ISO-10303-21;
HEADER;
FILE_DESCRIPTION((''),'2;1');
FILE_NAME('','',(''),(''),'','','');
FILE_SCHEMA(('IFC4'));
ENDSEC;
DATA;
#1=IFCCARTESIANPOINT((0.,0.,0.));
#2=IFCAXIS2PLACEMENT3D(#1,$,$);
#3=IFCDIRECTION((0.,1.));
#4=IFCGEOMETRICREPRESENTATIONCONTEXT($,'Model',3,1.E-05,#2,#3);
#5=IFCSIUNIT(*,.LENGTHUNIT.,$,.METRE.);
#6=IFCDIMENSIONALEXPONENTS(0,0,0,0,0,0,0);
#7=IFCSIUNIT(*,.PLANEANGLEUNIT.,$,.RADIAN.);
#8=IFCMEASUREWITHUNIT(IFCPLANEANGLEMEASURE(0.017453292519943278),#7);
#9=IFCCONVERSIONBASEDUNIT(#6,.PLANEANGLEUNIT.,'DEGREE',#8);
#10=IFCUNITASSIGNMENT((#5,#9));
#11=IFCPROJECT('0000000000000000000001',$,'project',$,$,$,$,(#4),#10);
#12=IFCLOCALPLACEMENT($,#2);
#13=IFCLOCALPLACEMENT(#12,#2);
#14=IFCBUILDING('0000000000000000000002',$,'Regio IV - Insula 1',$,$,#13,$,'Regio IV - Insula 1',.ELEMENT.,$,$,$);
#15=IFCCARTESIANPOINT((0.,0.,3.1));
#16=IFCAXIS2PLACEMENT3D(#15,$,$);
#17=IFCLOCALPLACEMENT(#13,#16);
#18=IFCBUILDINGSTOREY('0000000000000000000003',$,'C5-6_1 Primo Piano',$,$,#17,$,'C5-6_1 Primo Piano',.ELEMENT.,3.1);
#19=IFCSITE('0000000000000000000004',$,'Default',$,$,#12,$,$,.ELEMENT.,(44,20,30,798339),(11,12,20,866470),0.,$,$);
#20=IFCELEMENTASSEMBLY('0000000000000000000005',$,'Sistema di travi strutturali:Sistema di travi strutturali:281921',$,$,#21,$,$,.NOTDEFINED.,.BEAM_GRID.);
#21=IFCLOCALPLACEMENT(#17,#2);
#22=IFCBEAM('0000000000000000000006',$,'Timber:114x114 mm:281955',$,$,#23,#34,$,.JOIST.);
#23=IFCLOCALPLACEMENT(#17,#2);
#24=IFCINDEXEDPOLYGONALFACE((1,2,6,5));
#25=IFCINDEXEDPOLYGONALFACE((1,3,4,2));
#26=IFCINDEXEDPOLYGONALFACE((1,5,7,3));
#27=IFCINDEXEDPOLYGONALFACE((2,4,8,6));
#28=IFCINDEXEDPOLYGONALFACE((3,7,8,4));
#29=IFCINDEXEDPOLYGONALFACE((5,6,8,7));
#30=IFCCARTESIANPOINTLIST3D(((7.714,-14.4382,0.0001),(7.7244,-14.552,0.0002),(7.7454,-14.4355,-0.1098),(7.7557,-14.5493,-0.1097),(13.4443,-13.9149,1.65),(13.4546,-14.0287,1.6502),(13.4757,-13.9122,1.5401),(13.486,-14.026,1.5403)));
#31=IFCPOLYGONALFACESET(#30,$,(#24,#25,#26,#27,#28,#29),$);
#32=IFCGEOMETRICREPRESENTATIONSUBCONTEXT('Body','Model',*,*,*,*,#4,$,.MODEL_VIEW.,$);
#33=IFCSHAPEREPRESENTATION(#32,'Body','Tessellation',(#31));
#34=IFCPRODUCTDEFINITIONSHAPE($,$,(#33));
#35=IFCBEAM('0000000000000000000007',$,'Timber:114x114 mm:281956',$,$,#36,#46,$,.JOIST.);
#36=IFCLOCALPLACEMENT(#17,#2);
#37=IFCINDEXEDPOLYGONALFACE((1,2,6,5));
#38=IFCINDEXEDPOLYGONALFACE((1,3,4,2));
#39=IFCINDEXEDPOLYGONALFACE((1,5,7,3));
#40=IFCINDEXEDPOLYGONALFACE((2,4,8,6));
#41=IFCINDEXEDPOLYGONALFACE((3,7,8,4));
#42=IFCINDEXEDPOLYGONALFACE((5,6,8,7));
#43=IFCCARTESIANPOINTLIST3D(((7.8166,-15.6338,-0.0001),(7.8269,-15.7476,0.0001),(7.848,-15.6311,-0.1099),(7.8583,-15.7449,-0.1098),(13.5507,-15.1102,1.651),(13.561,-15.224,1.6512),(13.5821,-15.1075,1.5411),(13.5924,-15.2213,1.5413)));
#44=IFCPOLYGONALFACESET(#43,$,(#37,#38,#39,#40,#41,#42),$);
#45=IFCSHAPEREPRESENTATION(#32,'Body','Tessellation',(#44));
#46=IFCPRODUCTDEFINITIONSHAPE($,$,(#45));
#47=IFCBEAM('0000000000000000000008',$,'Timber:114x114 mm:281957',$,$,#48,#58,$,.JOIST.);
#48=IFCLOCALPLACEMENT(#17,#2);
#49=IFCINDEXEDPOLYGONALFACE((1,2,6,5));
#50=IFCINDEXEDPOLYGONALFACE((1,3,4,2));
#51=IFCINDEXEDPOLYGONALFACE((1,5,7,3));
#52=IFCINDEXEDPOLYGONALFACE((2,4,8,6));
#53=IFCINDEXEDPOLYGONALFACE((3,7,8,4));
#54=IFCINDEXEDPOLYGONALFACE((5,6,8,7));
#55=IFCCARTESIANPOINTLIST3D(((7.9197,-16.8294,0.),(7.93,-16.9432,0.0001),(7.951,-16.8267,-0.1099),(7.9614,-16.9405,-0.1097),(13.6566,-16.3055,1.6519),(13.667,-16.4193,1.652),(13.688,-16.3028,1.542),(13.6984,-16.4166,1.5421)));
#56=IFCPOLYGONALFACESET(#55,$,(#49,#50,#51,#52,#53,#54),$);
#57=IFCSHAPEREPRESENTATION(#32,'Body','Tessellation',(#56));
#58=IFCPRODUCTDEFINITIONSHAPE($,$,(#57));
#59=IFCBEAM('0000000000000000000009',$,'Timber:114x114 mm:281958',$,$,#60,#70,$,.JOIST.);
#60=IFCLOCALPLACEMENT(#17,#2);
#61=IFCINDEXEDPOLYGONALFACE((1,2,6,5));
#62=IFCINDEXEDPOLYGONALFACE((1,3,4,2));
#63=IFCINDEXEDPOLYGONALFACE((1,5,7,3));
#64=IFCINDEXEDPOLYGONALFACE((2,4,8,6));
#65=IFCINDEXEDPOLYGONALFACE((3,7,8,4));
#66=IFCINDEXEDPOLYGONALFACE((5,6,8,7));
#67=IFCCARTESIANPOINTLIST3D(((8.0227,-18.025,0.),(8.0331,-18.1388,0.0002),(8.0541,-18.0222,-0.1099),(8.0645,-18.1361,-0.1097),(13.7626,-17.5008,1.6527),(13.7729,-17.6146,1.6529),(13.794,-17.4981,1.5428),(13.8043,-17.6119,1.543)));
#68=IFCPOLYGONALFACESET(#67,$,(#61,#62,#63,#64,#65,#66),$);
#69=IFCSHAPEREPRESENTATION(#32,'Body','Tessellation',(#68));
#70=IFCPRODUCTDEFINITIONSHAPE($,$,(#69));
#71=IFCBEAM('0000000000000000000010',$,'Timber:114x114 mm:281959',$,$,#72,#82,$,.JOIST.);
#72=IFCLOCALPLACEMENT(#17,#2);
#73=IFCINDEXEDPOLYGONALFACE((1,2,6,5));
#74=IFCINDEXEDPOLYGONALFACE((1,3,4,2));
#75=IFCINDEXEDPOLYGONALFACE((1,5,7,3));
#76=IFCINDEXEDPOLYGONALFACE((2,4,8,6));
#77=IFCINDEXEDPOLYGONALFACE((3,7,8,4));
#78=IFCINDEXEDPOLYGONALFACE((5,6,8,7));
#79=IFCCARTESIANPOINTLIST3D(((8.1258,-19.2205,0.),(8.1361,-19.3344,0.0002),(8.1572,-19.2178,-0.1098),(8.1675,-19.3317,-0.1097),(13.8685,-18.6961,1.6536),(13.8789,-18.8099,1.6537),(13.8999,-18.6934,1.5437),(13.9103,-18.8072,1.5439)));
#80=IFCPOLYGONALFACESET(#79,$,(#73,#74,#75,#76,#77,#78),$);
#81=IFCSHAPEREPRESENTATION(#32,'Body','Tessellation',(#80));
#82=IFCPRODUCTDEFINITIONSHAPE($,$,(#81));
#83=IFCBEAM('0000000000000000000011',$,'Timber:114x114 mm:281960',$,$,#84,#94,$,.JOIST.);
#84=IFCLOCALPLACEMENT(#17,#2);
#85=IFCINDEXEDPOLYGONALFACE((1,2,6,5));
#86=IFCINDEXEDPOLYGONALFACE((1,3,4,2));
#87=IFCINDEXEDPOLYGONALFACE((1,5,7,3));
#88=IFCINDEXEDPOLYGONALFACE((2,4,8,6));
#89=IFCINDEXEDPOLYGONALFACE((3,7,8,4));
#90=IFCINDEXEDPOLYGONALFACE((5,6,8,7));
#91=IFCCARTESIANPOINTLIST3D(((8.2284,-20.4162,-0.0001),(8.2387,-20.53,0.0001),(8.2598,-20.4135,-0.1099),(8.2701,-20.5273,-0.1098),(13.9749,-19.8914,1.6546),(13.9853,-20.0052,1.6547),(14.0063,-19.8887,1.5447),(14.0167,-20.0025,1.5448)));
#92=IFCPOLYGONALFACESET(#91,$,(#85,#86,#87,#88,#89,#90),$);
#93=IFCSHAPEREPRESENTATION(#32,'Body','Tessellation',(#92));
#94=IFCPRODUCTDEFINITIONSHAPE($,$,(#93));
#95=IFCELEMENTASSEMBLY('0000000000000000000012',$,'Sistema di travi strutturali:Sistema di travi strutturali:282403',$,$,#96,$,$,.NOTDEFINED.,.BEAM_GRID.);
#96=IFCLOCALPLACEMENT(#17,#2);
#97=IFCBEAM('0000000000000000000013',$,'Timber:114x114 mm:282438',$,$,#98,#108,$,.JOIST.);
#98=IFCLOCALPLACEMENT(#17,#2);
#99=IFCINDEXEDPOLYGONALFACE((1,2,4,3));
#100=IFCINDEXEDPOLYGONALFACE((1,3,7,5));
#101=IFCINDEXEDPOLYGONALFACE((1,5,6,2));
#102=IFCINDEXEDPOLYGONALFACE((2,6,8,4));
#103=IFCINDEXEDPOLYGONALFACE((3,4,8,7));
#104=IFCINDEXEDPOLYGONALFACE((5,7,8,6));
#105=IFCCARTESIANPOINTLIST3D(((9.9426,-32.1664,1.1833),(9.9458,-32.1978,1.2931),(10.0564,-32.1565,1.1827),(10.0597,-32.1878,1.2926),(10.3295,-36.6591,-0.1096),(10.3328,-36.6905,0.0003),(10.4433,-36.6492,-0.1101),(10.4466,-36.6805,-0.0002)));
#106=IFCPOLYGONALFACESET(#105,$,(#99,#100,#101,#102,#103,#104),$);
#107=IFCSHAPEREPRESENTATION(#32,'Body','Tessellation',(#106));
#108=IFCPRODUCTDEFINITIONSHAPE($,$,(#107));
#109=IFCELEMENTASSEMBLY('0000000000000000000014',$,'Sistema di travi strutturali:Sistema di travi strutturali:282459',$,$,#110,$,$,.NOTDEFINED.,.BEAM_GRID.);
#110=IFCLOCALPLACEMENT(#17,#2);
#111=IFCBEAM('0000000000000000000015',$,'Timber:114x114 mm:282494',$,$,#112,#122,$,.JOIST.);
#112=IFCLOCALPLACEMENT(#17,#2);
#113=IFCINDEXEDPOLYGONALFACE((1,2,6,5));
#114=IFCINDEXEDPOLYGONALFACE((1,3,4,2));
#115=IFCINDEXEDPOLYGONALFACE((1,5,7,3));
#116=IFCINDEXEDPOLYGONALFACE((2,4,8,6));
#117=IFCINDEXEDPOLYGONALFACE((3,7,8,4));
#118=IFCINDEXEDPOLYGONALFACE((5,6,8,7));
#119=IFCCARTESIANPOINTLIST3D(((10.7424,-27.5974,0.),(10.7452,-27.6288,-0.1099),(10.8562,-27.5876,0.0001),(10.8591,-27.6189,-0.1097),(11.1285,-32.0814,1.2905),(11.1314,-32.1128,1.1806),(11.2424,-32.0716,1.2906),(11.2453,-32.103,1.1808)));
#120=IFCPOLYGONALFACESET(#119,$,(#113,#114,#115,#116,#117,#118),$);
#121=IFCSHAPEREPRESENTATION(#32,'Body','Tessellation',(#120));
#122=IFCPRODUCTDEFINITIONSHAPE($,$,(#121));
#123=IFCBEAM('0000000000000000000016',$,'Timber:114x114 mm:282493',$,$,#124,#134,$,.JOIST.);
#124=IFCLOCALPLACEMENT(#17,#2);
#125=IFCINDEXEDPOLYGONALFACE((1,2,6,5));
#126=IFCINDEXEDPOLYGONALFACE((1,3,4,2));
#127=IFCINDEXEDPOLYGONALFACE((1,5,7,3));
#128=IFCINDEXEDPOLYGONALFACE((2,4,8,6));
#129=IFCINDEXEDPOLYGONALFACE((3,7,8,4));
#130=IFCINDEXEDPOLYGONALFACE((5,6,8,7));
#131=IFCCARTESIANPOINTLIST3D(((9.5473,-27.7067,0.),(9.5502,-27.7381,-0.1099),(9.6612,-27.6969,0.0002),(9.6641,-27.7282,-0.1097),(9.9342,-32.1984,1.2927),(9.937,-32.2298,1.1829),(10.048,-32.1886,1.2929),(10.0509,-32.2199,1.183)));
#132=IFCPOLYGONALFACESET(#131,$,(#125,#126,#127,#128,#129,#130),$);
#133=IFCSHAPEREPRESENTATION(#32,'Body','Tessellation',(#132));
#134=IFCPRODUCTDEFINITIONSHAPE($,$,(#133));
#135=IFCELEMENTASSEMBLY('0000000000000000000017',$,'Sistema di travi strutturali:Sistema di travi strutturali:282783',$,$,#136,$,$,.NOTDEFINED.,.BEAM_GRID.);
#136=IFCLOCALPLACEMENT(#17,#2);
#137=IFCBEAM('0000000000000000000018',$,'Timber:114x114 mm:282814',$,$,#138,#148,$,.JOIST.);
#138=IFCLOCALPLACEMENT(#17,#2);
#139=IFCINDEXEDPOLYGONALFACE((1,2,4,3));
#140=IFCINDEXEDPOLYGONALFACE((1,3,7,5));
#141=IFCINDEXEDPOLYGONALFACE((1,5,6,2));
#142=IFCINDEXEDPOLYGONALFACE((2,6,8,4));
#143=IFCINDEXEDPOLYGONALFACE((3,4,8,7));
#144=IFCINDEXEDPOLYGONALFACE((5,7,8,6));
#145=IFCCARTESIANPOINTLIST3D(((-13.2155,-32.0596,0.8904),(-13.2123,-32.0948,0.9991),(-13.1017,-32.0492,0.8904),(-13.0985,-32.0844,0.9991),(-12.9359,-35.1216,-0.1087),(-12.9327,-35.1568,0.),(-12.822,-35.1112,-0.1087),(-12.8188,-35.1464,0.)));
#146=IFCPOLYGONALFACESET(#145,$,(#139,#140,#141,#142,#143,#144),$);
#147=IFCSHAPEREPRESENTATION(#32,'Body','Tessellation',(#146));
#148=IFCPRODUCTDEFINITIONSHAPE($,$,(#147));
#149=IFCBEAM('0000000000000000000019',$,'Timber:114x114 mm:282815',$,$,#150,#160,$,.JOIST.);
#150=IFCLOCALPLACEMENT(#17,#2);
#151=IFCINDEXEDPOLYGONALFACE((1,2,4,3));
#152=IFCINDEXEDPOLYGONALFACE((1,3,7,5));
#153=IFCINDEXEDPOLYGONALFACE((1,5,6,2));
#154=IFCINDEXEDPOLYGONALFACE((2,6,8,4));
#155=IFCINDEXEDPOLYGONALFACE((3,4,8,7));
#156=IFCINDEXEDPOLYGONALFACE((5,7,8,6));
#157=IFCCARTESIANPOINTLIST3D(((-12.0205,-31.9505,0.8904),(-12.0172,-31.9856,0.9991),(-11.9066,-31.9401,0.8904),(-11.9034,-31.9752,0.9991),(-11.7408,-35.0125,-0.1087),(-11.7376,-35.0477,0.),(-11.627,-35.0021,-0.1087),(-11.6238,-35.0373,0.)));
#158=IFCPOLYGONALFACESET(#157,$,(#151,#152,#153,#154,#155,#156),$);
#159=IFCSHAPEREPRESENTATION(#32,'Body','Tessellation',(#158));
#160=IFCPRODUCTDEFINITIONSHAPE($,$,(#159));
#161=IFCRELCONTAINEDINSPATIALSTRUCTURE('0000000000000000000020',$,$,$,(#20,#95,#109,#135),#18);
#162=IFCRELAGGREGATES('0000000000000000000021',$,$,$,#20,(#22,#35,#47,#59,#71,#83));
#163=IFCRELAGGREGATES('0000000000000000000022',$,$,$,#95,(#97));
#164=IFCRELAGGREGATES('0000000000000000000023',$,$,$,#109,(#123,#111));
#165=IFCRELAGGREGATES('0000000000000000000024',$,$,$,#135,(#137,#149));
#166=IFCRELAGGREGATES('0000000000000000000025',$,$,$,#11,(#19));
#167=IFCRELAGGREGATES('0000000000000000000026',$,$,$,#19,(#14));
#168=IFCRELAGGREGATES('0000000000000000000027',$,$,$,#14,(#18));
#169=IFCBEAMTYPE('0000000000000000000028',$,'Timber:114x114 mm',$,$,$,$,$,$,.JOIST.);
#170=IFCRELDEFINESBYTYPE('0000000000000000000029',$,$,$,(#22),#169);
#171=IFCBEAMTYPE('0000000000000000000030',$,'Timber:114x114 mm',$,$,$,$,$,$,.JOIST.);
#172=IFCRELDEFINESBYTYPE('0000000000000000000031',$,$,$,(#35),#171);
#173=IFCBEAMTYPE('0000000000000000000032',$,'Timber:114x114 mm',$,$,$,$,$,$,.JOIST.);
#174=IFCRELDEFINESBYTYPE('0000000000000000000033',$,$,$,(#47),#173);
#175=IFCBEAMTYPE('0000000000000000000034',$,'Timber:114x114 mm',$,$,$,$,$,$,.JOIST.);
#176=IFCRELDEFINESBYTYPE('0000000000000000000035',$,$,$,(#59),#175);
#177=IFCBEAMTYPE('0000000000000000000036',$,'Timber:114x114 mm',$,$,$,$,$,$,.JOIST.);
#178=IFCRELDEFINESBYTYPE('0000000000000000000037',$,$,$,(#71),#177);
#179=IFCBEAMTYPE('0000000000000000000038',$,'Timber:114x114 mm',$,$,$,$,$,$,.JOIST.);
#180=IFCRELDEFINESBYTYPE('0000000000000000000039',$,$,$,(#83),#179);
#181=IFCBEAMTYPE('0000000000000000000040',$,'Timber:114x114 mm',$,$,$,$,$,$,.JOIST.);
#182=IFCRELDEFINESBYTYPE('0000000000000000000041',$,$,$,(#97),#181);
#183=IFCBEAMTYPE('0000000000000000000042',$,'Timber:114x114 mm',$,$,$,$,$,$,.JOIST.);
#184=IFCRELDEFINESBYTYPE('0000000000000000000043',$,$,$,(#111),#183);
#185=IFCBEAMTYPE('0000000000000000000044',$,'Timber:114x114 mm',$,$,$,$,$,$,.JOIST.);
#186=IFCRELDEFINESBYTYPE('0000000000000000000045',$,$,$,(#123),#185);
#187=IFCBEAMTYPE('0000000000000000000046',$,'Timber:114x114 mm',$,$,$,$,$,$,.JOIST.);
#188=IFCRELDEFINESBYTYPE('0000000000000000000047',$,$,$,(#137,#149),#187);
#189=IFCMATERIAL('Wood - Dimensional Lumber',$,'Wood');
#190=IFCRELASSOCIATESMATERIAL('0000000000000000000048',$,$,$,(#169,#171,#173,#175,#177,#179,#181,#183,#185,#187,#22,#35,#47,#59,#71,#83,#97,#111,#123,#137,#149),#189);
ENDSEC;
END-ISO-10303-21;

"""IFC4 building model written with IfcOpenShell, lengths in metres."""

from ifc_helpers import new_model, entity, si_unit, converted_unit, direction, frame, origin, origin_2d_with_axis, place, context, subcontext, project, spatial, rectangle, extrude, source, transform, mapped, material, material_profile, profile_set, profile_usage, type_object, type_shapes, element, aggregate, save


model = new_model("IFC4")

# Units and contexts
model_context = context("Model", 3, precision=1e-05, world=origin(), true_north=direction((0.0, 1.0)))
body_context = subcontext(model_context, "Body", "Model", "MODEL_VIEW")
ifc_project = project(units=[si_unit("LENGTHUNIT", "METRE"), converted_unit("PLANEANGLEUNIT", "DEGREE", entity("IfcPlaneAngleMeasure", 0.017453292519943278), si_unit("PLANEANGLEUNIT", "RADIAN"), dimensions=[0, 0, 0, 0, 0, 0, 0])], contexts=[model_context])

# Site, building, storey
site_placement = place(None, origin())
site = spatial("IfcSite", under=ifc_project, at=site_placement, Name="Default", CompositionType="ELEMENT", RefLatitude=(44, 20, 30, 798339), RefLongitude=(11, 12, 20, 866470), RefElevation=0.0)
building_placement = place(site_placement, origin())
building = spatial("IfcBuilding", under=site, at=building_placement, Name="Regio IV - Insula 1", LongName="Regio IV - Insula 1", CompositionType="ELEMENT")
storey_placement = place(building_placement, frame((0.0, 0.0, 3.1)))
storey = spatial("IfcBuildingStorey", under=building, at=storey_placement, Name="C5-6_1 Primo Piano", LongName="C5-6_1 Primo Piano", CompositionType="ELEMENT", Elevation=3.1)

# Element assembly, beams
assembly_1_placement = place(storey_placement, origin())
assembly_1 = element("IfcElementAssembly", 1, at=assembly_1_placement, inside=storey, Name="Sistema di travi strutturali:Sistema di travi strutturali:281921", AssemblyPlace="NOTDEFINED", PredefinedType="BEAM_GRID")
ifc_material_1 = material(Name="Wood - Dimensional Lumber", Category="Wood")
ifc_material_profile_1 = material_profile(ifc_material_1, rectangle(XDim=5.294, YDim=0.1143, at=origin_2d_with_axis()), Name="114x114 mm")
ifc_profile_set_1 = profile_set([ifc_material_profile_1], Name="114x114 mm")
ifc_profile_usage_1 = profile_usage(ifc_profile_set_1, cardinal=8)
beam_type_1 = type_object("IfcBeamType", Name="Timber:114x114 mm", PredefinedType="JOIST", material=ifc_profile_set_1)
shared_shape_1 = source(origin(), body_context, "Body", "SweptSolid", [
    extrude(rectangle(XDim=5.986, YDim=0.1143, at=origin_2d_with_axis()), frame((0.0, 0.0, -0.0572), z_axis=(0.0, 0.0, 1.0), x_axis=(-1.0, 0.0, 0.0)), (0.0, 0.0, 1.0), 0.1143),
])
type_shapes(beam_type_1, [shared_shape_1])
beam_1_placement = place(assembly_1_placement, frame((10.6, -14.2321, 0.7702), z_axis=(-0.274621, -0.02365, 0.961262), x_axis=(-0.957279, -0.087418, -0.275634)))
beam_1 = element("IfcBeam", 2, at=beam_1_placement, type_object=beam_type_1, material=ifc_profile_usage_1, Name="Timber:114x114 mm:281955", PredefinedType="JOIST", context=body_context, shape_type="MappedRepresentation", body=[
    mapped(shared_shape_1, transform((0.0, 0.0, 0.0), scale=1.0)),
])
beam_type_2 = type_object("IfcBeamType", Name="Timber:114x114 mm", PredefinedType="JOIST", material=ifc_profile_set_1)
shared_shape_2 = source(origin(), body_context, "Body", "SweptSolid", [
    extrude(rectangle(XDim=5.99, YDim=0.1143, at=origin_2d_with_axis()), frame((0.0, 0.0, -0.0572), z_axis=(0.0, 0.0, 1.0), x_axis=(-1.0, 0.0, 0.0)), (0.0, 0.0, 1.0), 0.1143),
])
type_shapes(beam_type_2, [shared_shape_2])
beam_2_placement = place(assembly_1_placement, frame((10.7045, -15.4275, 0.7706), z_axis=(-0.274621, -0.02365, 0.961262), x_axis=(-0.957279, -0.087418, -0.275634)))
beam_2 = element("IfcBeam", 3, at=beam_2_placement, type_object=beam_type_2, material=ifc_profile_usage_1, Name="Timber:114x114 mm:281956", PredefinedType="JOIST", context=body_context, shape_type="MappedRepresentation", body=[
    mapped(shared_shape_2, transform((0.0, 0.0, 0.0), scale=1.0)),
])
beam_type_3 = type_object("IfcBeamType", Name="Timber:114x114 mm", PredefinedType="JOIST", material=ifc_profile_set_1)
shared_shape_3 = source(origin(), body_context, "Body", "SweptSolid", [
    extrude(rectangle(XDim=5.993, YDim=0.1143, at=origin_2d_with_axis()), frame((0.0, 0.0, -0.0572), z_axis=(0.0, 0.0, 1.0), x_axis=(-1.0, 0.0, 0.0)), (0.0, 0.0, 1.0), 0.1143),
])
type_shapes(beam_type_3, [shared_shape_3])
beam_3_placement = place(assembly_1_placement, frame((10.809, -16.623, 0.7711), z_axis=(-0.274621, -0.02365, 0.961262), x_axis=(-0.957279, -0.087418, -0.275634)))
beam_3 = element("IfcBeam", 4, at=beam_3_placement, type_object=beam_type_3, material=ifc_profile_usage_1, Name="Timber:114x114 mm:281957", PredefinedType="JOIST", context=body_context, shape_type="MappedRepresentation", body=[
    mapped(shared_shape_3, transform((0.0, 0.0, 0.0), scale=1.0)),
])
beam_type_4 = type_object("IfcBeamType", Name="Timber:114x114 mm", PredefinedType="JOIST", material=ifc_profile_set_1)
shared_shape_4 = source(origin(), body_context, "Body", "SweptSolid", [
    extrude(rectangle(XDim=5.996, YDim=0.1143, at=origin_2d_with_axis()), frame((0.0, 0.0, -0.0572), z_axis=(0.0, 0.0, 1.0), x_axis=(-1.0, 0.0, 0.0)), (0.0, 0.0, 1.0), 0.1143),
])
type_shapes(beam_type_4, [shared_shape_4])
beam_4_placement = place(assembly_1_placement, frame((10.9135, -17.8184, 0.7715), z_axis=(-0.274621, -0.02365, 0.961262), x_axis=(-0.957279, -0.087418, -0.275634)))
beam_4 = element("IfcBeam", 5, at=beam_4_placement, type_object=beam_type_4, material=ifc_profile_usage_1, Name="Timber:114x114 mm:281958", PredefinedType="JOIST", context=body_context, shape_type="MappedRepresentation", body=[
    mapped(shared_shape_4, transform((0.0, 0.0, 0.0), scale=1.0)),
])
beam_type_5 = type_object("IfcBeamType", Name="Timber:114x114 mm", PredefinedType="JOIST", material=ifc_profile_set_1)
shared_shape_5 = source(origin(), body_context, "Body", "SweptSolid", [
    extrude(rectangle(XDim=5.999, YDim=0.1143, at=origin_2d_with_axis()), frame((0.0, 0.0, -0.0572), z_axis=(0.0, 0.0, 1.0), x_axis=(-1.0, 0.0, 0.0)), (0.0, 0.0, 1.0), 0.1143),
])
type_shapes(beam_type_5, [shared_shape_5])
beam_5_placement = place(assembly_1_placement, frame((11.018, -19.0139, 0.7719), z_axis=(-0.274621, -0.02365, 0.961262), x_axis=(-0.957279, -0.087418, -0.275634)))
beam_5 = element("IfcBeam", 6, at=beam_5_placement, type_object=beam_type_5, material=ifc_profile_usage_1, Name="Timber:114x114 mm:281959", PredefinedType="JOIST", context=body_context, shape_type="MappedRepresentation", body=[
    mapped(shared_shape_5, transform((0.0, 0.0, 0.0), scale=1.0)),
])
beam_type_6 = type_object("IfcBeamType", Name="Timber:114x114 mm", PredefinedType="JOIST", material=ifc_profile_set_1)
shared_shape_6 = source(origin(), body_context, "Body", "SweptSolid", [
    extrude(rectangle(XDim=6.003, YDim=0.1143, at=origin_2d_with_axis()), frame((0.0, 0.0, -0.0572), z_axis=(0.0, 0.0, 1.0), x_axis=(-1.0, 0.0, 0.0)), (0.0, 0.0, 1.0), 0.1143),
])
type_shapes(beam_type_6, [shared_shape_6])
beam_6_placement = place(assembly_1_placement, frame((11.1225, -20.2093, 0.7724), z_axis=(-0.274621, -0.02365, 0.961262), x_axis=(-0.957279, -0.087418, -0.275634)))
beam_6 = element("IfcBeam", 7, at=beam_6_placement, type_object=beam_type_6, material=ifc_profile_usage_1, Name="Timber:114x114 mm:281960", PredefinedType="JOIST", context=body_context, shape_type="MappedRepresentation", body=[
    mapped(shared_shape_6, transform((0.0, 0.0, 0.0), scale=1.0)),
])
aggregate(assembly_1, [beam_1, beam_2, beam_3, beam_4, beam_5, beam_6])

# Element assembly, beam
assembly_2_placement = place(storey_placement, origin())
assembly_2 = element("IfcElementAssembly", 8, at=assembly_2_placement, inside=storey, Name="Sistema di travi strutturali:Sistema di travi strutturali:282403", AssemblyPlace="NOTDEFINED", PredefinedType="BEAM_GRID")
beam_type_7 = type_object("IfcBeamType", Name="Timber:114x114 mm", PredefinedType="JOIST", material=ifc_profile_set_1)
shared_shape_7 = source(origin(), body_context, "Body", "SweptSolid", [
    extrude(rectangle(XDim=4.691, YDim=0.1143, at=origin_2d_with_axis()), frame((0.0, 0.0, -0.0572), z_axis=(0.0, 0.0, 1.0), x_axis=(-1.0, 0.0, 0.0)), (0.0, 0.0, 1.0), 0.1143),
])
type_shapes(beam_type_7, [shared_shape_7])
beam_7_placement = place(assembly_2_placement, frame((10.1946, -34.4235, 0.5915), z_axis=(0.028737, -0.274135, 0.961262), x_axis=(0.082478, -0.957729, -0.275594)))
beam_7 = element("IfcBeam", 9, at=beam_7_placement, type_object=beam_type_7, material=ifc_profile_usage_1, Name="Timber:114x114 mm:282438", PredefinedType="JOIST", context=body_context, shape_type="MappedRepresentation", body=[
    mapped(shared_shape_7, transform((0.0, 0.0, 0.0), scale=1.0)),
])
aggregate(assembly_2, [beam_7])

# Element assemblies, beams
assembly_3_placement = place(storey_placement, origin())
assembly_3 = element("IfcElementAssembly", 10, at=assembly_3_placement, inside=storey, Name="Sistema di travi strutturali:Sistema di travi strutturali:282459", AssemblyPlace="NOTDEFINED", PredefinedType="BEAM_GRID")
beam_type_8 = type_object("IfcBeamType", Name="Timber:114x114 mm", PredefinedType="JOIST", material=ifc_profile_set_1)
shared_shape_8 = source(origin(), body_context, "Body", "SweptSolid", [
    extrude(rectangle(XDim=4.682, YDim=0.1143, at=origin_2d_with_axis()), frame((0.0, 0.0, -0.0572), z_axis=(0.0, 0.0, 1.0), x_axis=(-1.0, 0.0, 0.0)), (0.0, 0.0, 1.0), 0.1143),
])
type_shapes(beam_type_8, [shared_shape_8])
beam_8_placement = place(assembly_3_placement, frame((10.9938, -29.8502, 0.5904), z_axis=(-0.025067, 0.274495, 0.961262), x_axis=(0.082477, -0.957718, 0.275634)))
beam_8 = element("IfcBeam", 11, at=beam_8_placement, type_object=beam_type_8, material=ifc_profile_usage_1, Name="Timber:114x114 mm:282494", PredefinedType="JOIST", context=body_context, shape_type="MappedRepresentation", body=[
    mapped(shared_shape_8, transform((0.0, 0.0, 0.0), scale=1.0)),
])
beam_type_9 = type_object("IfcBeamType", Name="Timber:114x114 mm", PredefinedType="JOIST", material=ifc_profile_set_1)
shared_shape_9 = source(origin(), body_context, "Body", "SweptSolid", [
    extrude(rectangle(XDim=4.69, YDim=0.1143, at=origin_2d_with_axis()), frame((0.0, 0.0, -0.0572), z_axis=(0.0, 0.0, 1.0), x_axis=(-1.0, 0.0, 0.0)), (0.0, 0.0, 1.0), 0.1143),
])
type_shapes(beam_type_9, [shared_shape_9])
beam_9_placement = place(assembly_3_placement, frame((9.7991, -29.9633, 0.5915), z_axis=(-0.025067, 0.274495, 0.961262), x_axis=(0.082477, -0.957718, 0.275634)))
beam_9 = element("IfcBeam", 12, at=beam_9_placement, type_object=beam_type_9, material=ifc_profile_usage_1, Name="Timber:114x114 mm:282493", PredefinedType="JOIST", context=body_context, shape_type="MappedRepresentation", body=[
    mapped(shared_shape_9, transform((0.0, 0.0, 0.0), scale=1.0)),
])
aggregate(assembly_3, [beam_9, beam_8])
assembly_4_placement = place(storey_placement, origin())
assembly_4 = element("IfcElementAssembly", 13, at=assembly_4_placement, inside=storey, Name="Sistema di travi strutturali:Sistema di travi strutturali:282783", AssemblyPlace="NOTDEFINED", PredefinedType="BEAM_GRID")
beam_type_10 = type_object("IfcBeamType", Name="Timber:114x114 mm", PredefinedType="JOIST", material=ifc_profile_set_1)
shared_shape_10 = source(origin(), body_context, "Body", "SweptSolid", [
    extrude(rectangle(XDim=3.233, YDim=0.1143, at=origin_2d_with_axis()), frame((0.0, 0.0, -0.0572), z_axis=(0.0, 0.0, 1.0), x_axis=(-1.0, 0.0, 0.0)), (0.0, 0.0, 1.0), 0.1143),
])
type_shapes(beam_type_10, [shared_shape_10])
beam_10_placement = place(assembly_4_placement, frame((-13.0172, -33.603, 0.4452), z_axis=(0.028102, -0.307737, 0.951057), x_axis=(0.08649, -0.947116, -0.309017)))
beam_10 = element("IfcBeam", 14, at=beam_10_placement, type_object=beam_type_10, material=ifc_profile_usage_1, Name="Timber:114x114 mm:282814", PredefinedType="JOIST", context=body_context, shape_type="MappedRepresentation", body=[
    mapped(shared_shape_10, transform((0.0, 0.0, 0.0), scale=1.0)),
])
beam_11_placement = place(assembly_4_placement, frame((-11.8221, -33.4939, 0.4452), z_axis=(0.028102, -0.307737, 0.951057), x_axis=(0.08649, -0.947116, -0.309017)))
beam_11 = element("IfcBeam", 15, at=beam_11_placement, type_object=beam_type_10, material=ifc_profile_usage_1, Name="Timber:114x114 mm:282815", PredefinedType="JOIST", context=body_context, shape_type="MappedRepresentation", body=[
    mapped(shared_shape_10, transform((0.0, 0.0, 0.0), scale=1.0)),
])
aggregate(assembly_4, [beam_10, beam_11])

save(model, "model.ifc")
